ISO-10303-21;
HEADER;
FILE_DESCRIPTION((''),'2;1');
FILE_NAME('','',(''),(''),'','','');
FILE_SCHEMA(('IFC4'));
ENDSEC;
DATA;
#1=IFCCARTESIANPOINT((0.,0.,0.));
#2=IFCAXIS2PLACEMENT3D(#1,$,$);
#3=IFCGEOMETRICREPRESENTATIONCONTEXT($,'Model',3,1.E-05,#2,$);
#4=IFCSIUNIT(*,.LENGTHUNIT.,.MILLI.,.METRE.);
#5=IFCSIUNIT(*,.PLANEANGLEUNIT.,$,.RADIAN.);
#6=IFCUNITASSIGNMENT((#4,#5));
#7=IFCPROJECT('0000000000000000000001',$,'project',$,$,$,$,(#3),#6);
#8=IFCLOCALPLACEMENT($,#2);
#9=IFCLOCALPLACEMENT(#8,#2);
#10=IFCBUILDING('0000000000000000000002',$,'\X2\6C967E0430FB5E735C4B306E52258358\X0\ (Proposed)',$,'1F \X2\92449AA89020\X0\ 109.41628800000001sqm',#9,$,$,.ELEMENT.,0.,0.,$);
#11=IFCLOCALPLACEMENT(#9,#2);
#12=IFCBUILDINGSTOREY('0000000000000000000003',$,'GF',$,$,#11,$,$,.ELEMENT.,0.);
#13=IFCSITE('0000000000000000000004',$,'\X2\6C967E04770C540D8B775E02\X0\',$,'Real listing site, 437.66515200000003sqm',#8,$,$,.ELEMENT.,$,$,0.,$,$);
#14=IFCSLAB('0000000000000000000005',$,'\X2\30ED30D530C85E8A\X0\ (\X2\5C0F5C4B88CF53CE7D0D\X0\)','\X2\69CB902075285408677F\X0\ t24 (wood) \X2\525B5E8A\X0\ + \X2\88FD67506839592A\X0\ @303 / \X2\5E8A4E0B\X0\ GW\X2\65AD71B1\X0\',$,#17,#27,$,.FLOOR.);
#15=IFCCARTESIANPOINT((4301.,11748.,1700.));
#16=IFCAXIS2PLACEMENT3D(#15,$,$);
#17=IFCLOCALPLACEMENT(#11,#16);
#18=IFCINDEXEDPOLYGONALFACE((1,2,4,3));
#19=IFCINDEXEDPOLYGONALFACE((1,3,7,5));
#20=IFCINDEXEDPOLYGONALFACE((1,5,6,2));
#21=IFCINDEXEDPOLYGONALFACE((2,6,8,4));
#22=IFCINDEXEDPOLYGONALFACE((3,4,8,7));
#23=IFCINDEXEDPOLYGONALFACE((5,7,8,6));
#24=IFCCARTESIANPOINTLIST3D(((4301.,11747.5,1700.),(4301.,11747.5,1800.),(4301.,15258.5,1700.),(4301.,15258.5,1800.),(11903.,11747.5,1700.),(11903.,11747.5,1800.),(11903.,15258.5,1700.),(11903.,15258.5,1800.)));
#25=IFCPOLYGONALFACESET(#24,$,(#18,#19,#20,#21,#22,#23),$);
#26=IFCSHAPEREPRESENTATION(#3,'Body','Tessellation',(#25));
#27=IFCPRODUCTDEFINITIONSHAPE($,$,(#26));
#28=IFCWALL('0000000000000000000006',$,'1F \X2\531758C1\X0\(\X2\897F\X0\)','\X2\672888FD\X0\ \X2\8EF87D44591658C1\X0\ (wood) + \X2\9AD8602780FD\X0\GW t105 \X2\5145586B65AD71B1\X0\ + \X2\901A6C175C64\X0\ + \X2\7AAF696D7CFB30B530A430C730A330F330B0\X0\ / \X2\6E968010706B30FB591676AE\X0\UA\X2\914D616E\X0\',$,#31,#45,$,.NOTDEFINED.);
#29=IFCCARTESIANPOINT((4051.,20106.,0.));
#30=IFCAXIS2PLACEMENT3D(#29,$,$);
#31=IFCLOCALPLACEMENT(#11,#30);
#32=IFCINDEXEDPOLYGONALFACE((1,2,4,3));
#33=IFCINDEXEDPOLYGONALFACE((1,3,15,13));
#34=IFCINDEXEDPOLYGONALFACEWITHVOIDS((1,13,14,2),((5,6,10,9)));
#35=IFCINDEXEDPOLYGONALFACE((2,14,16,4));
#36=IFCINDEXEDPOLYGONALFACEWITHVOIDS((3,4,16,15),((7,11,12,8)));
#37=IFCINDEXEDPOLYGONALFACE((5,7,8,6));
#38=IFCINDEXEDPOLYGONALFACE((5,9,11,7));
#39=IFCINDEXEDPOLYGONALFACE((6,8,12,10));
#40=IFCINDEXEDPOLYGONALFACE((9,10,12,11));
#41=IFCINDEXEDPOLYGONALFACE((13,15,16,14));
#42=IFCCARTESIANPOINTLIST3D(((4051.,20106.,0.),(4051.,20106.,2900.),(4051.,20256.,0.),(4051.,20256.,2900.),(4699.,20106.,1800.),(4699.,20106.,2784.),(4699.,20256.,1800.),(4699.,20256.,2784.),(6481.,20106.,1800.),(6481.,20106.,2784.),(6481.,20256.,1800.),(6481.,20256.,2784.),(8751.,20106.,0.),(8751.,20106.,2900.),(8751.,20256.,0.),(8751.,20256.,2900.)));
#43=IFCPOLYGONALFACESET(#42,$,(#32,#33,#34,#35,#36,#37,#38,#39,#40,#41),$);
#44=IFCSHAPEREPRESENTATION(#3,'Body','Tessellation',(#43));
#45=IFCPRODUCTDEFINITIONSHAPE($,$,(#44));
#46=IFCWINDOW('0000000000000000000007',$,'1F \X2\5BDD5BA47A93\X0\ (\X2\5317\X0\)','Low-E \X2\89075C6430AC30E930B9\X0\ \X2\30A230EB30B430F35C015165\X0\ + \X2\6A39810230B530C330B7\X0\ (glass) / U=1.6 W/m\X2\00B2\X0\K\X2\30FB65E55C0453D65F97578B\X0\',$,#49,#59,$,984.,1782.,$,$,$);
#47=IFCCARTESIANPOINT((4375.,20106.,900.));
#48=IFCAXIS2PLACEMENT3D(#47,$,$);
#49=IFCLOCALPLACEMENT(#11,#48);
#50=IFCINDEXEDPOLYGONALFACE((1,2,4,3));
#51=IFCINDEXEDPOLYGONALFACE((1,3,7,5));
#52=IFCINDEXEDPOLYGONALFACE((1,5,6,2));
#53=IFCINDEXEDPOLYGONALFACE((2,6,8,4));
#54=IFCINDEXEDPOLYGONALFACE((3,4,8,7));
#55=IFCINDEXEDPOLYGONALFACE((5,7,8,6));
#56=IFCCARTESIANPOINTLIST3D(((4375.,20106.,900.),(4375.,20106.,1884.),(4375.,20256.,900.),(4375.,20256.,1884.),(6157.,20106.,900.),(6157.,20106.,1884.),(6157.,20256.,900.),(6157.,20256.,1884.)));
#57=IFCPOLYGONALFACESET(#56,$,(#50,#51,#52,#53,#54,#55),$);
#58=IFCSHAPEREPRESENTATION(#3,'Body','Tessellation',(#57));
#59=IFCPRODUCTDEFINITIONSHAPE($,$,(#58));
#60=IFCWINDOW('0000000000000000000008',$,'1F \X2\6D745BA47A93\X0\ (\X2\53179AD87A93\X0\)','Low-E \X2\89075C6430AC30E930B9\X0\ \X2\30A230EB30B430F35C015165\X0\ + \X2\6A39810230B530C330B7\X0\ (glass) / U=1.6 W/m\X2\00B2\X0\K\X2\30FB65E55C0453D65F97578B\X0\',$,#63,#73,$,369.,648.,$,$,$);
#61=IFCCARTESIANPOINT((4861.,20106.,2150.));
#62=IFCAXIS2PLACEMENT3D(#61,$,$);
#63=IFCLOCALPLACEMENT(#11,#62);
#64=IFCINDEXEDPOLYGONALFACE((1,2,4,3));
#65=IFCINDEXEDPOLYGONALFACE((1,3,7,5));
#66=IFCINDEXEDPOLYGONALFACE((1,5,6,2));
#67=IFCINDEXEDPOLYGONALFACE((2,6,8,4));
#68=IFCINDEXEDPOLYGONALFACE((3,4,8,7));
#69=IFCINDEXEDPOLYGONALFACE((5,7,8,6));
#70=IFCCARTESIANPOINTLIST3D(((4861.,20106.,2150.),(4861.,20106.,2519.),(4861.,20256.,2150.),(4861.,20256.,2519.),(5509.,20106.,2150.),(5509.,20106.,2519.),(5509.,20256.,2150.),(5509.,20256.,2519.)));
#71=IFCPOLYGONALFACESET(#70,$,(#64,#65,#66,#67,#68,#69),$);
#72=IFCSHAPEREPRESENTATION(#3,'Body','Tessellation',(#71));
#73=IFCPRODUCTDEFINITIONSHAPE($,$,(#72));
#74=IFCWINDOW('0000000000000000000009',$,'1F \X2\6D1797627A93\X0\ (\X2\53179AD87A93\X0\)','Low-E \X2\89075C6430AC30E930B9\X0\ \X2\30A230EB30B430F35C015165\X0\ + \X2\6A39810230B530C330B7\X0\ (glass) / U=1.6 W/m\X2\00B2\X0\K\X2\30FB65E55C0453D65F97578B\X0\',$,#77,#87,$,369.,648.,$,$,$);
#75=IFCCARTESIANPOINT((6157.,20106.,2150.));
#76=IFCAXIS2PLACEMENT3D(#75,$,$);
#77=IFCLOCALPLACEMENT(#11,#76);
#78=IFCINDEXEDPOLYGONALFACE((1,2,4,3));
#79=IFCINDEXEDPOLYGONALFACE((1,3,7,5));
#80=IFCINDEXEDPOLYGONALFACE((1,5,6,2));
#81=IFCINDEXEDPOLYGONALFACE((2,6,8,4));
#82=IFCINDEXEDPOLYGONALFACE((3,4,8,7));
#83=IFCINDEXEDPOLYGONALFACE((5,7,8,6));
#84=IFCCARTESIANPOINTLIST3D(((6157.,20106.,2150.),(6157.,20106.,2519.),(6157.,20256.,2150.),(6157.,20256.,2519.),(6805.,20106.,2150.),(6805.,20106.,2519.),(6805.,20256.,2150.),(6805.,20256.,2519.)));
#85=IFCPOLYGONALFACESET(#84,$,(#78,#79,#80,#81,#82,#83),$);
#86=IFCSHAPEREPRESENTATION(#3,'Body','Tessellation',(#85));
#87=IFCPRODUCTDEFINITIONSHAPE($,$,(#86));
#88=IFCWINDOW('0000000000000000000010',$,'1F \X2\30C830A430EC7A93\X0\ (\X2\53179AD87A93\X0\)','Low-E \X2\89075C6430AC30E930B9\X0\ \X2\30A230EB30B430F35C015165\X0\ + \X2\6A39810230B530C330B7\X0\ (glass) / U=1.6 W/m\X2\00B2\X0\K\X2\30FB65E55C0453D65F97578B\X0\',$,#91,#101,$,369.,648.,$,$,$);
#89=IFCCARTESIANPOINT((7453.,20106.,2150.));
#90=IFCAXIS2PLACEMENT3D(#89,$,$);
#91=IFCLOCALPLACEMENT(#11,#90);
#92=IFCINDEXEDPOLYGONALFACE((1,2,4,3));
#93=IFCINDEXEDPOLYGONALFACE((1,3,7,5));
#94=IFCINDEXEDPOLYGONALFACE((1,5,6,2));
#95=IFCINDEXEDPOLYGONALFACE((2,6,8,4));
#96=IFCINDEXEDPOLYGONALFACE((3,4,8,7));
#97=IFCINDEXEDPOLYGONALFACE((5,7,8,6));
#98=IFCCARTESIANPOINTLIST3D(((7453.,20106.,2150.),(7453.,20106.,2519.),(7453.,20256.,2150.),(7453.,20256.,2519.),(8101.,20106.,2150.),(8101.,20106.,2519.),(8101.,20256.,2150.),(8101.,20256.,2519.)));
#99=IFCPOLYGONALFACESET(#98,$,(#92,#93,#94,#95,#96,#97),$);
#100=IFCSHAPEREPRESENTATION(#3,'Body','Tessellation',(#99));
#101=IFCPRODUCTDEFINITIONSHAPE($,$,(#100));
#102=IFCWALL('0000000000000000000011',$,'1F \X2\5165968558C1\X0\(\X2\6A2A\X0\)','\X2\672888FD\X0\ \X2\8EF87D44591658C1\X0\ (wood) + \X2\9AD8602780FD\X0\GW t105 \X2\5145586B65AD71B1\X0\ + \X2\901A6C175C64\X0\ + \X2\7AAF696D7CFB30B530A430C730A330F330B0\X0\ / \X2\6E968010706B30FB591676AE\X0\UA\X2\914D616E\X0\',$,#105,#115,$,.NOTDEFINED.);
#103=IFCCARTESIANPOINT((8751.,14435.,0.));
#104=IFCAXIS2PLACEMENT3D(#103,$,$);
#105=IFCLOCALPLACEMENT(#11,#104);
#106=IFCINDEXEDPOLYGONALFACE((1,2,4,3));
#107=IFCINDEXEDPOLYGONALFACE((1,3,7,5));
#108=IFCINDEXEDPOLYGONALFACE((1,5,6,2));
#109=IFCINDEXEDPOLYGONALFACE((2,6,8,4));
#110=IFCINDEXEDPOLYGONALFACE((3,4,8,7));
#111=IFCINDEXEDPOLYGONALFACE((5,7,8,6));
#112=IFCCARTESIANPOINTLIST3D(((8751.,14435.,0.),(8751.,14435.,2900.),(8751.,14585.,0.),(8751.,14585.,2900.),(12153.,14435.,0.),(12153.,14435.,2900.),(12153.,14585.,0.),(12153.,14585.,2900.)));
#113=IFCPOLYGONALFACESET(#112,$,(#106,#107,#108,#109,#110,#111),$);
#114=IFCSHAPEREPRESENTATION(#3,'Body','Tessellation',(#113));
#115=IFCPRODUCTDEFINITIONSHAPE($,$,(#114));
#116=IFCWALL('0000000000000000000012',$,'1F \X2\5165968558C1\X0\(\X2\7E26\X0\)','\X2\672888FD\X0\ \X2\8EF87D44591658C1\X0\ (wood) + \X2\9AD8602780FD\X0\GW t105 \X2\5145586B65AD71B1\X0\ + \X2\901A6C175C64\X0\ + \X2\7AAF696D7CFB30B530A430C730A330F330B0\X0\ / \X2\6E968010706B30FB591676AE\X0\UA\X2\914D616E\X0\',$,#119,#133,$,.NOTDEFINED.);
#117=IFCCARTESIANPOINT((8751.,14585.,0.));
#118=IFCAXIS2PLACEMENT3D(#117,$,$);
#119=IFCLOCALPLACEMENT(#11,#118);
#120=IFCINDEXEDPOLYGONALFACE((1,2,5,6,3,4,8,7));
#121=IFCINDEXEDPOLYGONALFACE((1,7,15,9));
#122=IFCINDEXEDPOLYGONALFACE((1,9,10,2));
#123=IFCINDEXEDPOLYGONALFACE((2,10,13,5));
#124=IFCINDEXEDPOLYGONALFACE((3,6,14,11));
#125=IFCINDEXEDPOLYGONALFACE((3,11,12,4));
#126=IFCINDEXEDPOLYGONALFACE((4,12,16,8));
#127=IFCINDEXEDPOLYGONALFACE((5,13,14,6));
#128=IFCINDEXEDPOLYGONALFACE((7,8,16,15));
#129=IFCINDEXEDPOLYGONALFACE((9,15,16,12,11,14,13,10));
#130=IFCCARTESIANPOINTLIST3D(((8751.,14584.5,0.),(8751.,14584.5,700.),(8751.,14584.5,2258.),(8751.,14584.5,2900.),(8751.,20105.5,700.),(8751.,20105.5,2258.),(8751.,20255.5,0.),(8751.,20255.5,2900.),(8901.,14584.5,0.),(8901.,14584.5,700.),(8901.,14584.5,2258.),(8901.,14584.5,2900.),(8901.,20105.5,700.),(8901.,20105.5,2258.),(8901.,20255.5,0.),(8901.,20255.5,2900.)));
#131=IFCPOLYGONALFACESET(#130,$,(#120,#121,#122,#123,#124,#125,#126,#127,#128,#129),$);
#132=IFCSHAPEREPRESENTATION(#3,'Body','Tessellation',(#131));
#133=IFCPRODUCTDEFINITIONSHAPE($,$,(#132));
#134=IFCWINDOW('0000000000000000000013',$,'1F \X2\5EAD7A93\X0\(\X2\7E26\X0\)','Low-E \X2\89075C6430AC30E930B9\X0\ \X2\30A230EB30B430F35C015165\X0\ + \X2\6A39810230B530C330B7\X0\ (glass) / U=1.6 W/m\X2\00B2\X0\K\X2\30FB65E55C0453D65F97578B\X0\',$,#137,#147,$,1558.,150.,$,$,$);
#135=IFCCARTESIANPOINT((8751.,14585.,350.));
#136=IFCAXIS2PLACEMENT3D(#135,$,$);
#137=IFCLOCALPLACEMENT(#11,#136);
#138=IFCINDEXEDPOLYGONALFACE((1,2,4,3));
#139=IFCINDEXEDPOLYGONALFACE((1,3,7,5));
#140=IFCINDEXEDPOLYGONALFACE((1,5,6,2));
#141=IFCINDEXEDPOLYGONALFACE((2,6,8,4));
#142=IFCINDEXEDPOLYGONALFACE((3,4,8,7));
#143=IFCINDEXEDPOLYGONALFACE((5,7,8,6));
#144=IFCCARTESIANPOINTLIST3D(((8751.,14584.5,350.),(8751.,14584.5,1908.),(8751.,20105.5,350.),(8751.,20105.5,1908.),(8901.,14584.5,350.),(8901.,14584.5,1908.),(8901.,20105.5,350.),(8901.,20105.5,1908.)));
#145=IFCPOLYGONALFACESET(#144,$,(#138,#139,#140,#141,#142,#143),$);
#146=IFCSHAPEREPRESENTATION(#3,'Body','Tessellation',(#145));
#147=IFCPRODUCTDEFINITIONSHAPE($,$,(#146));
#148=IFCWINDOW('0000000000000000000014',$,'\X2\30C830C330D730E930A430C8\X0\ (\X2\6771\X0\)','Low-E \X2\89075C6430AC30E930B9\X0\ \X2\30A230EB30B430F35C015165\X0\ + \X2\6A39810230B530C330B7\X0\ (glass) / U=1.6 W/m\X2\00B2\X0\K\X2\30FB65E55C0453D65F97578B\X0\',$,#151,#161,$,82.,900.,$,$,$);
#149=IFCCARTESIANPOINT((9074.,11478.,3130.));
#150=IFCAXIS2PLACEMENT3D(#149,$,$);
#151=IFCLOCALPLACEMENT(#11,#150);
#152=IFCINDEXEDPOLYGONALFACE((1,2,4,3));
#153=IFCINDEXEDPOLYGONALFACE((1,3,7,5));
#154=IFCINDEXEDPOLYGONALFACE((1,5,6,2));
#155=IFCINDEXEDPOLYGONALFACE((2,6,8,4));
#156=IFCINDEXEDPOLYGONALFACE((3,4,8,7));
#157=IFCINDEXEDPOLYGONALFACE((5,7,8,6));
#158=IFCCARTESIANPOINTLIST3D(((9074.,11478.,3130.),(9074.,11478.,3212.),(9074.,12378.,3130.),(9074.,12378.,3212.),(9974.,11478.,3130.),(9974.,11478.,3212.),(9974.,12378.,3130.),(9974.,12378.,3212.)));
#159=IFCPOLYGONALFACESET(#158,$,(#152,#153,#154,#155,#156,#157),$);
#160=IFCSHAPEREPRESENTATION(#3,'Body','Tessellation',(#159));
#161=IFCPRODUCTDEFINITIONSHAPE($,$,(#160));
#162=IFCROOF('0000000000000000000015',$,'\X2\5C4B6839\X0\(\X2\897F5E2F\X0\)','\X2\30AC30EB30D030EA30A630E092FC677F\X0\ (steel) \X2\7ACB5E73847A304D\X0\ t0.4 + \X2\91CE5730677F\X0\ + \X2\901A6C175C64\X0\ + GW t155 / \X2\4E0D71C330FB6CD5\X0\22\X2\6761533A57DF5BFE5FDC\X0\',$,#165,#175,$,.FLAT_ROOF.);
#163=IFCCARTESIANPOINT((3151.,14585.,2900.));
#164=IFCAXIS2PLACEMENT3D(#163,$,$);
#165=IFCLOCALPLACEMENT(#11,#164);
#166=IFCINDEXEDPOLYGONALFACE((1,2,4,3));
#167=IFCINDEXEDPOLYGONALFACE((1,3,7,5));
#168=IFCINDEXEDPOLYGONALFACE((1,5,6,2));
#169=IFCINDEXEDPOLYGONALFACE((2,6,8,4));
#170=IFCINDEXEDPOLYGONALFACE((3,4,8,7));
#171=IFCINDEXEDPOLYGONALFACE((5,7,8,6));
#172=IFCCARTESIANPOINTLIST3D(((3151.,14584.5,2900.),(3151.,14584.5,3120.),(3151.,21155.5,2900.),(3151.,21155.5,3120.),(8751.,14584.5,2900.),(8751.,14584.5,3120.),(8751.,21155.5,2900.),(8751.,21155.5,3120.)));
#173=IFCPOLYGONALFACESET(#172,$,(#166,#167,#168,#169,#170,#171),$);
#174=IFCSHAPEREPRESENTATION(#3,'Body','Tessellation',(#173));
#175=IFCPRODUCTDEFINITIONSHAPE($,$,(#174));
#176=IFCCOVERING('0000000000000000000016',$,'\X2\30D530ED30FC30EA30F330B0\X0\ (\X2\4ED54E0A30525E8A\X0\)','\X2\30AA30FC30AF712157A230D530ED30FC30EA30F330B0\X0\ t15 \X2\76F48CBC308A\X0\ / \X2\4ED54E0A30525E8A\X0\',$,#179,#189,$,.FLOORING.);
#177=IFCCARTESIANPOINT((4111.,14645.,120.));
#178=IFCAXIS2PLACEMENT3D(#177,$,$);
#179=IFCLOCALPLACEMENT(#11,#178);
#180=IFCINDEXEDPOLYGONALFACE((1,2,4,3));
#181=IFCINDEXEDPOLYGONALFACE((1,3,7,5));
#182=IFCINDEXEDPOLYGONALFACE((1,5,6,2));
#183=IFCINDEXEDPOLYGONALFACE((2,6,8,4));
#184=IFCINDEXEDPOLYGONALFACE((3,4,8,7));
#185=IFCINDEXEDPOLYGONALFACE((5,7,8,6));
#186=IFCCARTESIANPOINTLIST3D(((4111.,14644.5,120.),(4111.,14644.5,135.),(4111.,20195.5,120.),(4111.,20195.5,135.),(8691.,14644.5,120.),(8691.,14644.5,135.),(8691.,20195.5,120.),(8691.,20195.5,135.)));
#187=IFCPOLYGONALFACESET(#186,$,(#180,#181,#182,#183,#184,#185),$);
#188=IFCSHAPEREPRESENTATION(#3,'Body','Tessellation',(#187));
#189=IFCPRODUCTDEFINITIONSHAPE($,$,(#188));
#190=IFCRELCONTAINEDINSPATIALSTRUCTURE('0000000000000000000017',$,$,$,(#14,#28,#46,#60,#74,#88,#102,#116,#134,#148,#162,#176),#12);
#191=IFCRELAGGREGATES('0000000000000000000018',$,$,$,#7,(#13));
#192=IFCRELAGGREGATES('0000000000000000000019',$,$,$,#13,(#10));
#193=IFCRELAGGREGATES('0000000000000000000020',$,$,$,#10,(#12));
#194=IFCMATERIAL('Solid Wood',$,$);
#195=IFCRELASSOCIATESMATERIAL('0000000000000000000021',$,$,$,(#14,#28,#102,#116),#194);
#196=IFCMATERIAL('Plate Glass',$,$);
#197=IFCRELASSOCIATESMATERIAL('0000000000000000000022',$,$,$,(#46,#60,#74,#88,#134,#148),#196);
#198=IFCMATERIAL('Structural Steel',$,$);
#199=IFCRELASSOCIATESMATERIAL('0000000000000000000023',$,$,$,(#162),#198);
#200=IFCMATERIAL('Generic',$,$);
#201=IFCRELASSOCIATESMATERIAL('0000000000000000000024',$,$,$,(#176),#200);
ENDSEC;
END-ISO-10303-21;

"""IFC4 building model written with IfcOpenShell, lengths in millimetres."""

from ifc_helpers import new_model, si_unit, frame, frame_2d, origin, place, context, project, spatial, rectangle, extrude, material, element, fill, save


model = new_model("IFC4")

# Units and contexts
model_context = context("Model", 3, precision=1e-05, world=origin())
ifc_project = project(units=[si_unit("LENGTHUNIT", "METRE", prefix="MILLI"), si_unit("PLANEANGLEUNIT", "RADIAN")], contexts=[model_context])

# Site, building, storey
site_placement = place(None, origin())
site = spatial("IfcSite", under=ifc_project, at=site_placement, Name="沖縄県名護市", ObjectType="Real listing site, 437.66515200000003sqm", CompositionType="ELEMENT", RefElevation=0.0)
building_placement = place(site_placement, origin())
building = spatial("IfcBuilding", under=site, at=building_placement, Name="沖縄・平屋の別荘 (Proposed)", ObjectType="1F 鉄骨造 109.41628800000001sqm", CompositionType="ELEMENT", ElevationOfRefHeight=0.0, ElevationOfTerrain=0.0)
storey_placement = place(building_placement, origin())
storey = spatial("IfcBuildingStorey", under=building, at=storey_placement, Name="GF", CompositionType="ELEMENT", Elevation=0.0)

# Slab
ifc_material_1 = material(Name="Solid Wood")
slab_1_placement = place(storey_placement, frame((4301.0, 11748.0, 1700.0)))
element("IfcSlab", 1, at=slab_1_placement, inside=storey, material=ifc_material_1, Name="ロフト床 (小屋裏収納)", Description="構造用合板 t24 (wood) 剛床 + 製材根太 @303 / 床下 GW断熱", PredefinedType="FLOOR", context=model_context, shape_type="SweptSolid", body=[
    extrude(rectangle(XDim=7602.0, YDim=3511.0, at=frame_2d((3801.0, 1755.0))), frame((4301.0, 11748.0, 1700.0)), (0.0, 0.0, 1.0), 100.0),
])

# Wall, openings, windows
wall_1_placement = place(storey_placement, frame((4051.0, 20106.0, 0.0)))
wall_1 = element("IfcWall", 2, at=wall_1_placement, inside=storey, material=ifc_material_1, Name="1F 北壁(西)", Description="木製 軸組外壁 (wood) + 高性能GW t105 充填断熱 + 通気層 + 窯業系サイディング / 準耐火・外皮UA配慮", PredefinedType="NOTDEFINED", context=model_context, shape_type="SweptSolid", body=[
    extrude(rectangle(XDim=4700.0, YDim=150.0, at=frame_2d((2350.0, 75.0))), frame((4051.0, 20106.0, 0.0)), (0.0, 0.0, 1.0), 2900.0),
])
opening_1_placement = place(storey_placement, frame((4375.0, 20106.0, 900.0)))
opening_1 = element("IfcOpeningElement", 3, at=opening_1_placement, cuts=wall_1, PredefinedType="NOTDEFINED", context=model_context, shape_type="SweptSolid", body=[
    extrude(rectangle(XDim=1782.0, YDim=150.0, at=frame_2d((891.0, 75.0))), frame((4375.0, 20106.0, 900.0)), (0.0, 0.0, 1.0), 984.0),
])
opening_2_placement = place(storey_placement, frame((4861.0, 20106.0, 2150.0)))
opening_2 = element("IfcOpeningElement", 4, at=opening_2_placement, cuts=wall_1, PredefinedType="NOTDEFINED", context=model_context, shape_type="SweptSolid", body=[
    extrude(rectangle(XDim=648.0, YDim=150.0, at=frame_2d((324.0, 75.0))), frame((4861.0, 20106.0, 2150.0)), (0.0, 0.0, 1.0), 369.0),
])
opening_3_placement = place(storey_placement, frame((6157.0, 20106.0, 2150.0)))
opening_3 = element("IfcOpeningElement", 5, at=opening_3_placement, cuts=wall_1, PredefinedType="NOTDEFINED", context=model_context, shape_type="SweptSolid", body=[
    extrude(rectangle(XDim=648.0, YDim=150.0, at=frame_2d((324.0, 75.0))), frame((6157.0, 20106.0, 2150.0)), (0.0, 0.0, 1.0), 369.0),
])
opening_4_placement = place(storey_placement, frame((7453.0, 20106.0, 2150.0)))
opening_4 = element("IfcOpeningElement", 6, at=opening_4_placement, cuts=wall_1, PredefinedType="NOTDEFINED", context=model_context, shape_type="SweptSolid", body=[
    extrude(rectangle(XDim=648.0, YDim=150.0, at=frame_2d((324.0, 75.0))), frame((7453.0, 20106.0, 2150.0)), (0.0, 0.0, 1.0), 369.0),
])
ifc_material_2 = material(Name="Plate Glass")
window_1_placement = place(storey_placement, frame((4375.0, 20106.0, 900.0)))
window_1 = element("IfcWindow", 7, at=window_1_placement, inside=storey, material=ifc_material_2, Name="1F 寝室窓 (北)", Description="Low-E 複層ガラス アルゴン封入 + 樹脂サッシ (glass) / U=1.6 W/m²K・日射取得型", OverallHeight=984.0, OverallWidth=1782.0, context=model_context, shape_type="SweptSolid", body=[
    extrude(rectangle(XDim=1782.0, YDim=150.0, at=frame_2d((891.0, 75.0))), frame((4375.0, 20106.0, 900.0)), (0.0, 0.0, 1.0), 984.0),
])
fill(opening_1, window_1)
window_2_placement = place(storey_placement, frame((4861.0, 20106.0, 2150.0)))
window_2 = element("IfcWindow", 8, at=window_2_placement, inside=storey, material=ifc_material_2, Name="1F 浴室窓 (北高窓)", Description="Low-E 複層ガラス アルゴン封入 + 樹脂サッシ (glass) / U=1.6 W/m²K・日射取得型", OverallHeight=369.0, OverallWidth=648.0, context=model_context, shape_type="SweptSolid", body=[
    extrude(rectangle(XDim=648.0, YDim=150.0, at=frame_2d((324.0, 75.0))), frame((4861.0, 20106.0, 2150.0)), (0.0, 0.0, 1.0), 369.0),
])
fill(opening_2, window_2)
window_3_placement = place(storey_placement, frame((6157.0, 20106.0, 2150.0)))
window_3 = element("IfcWindow", 9, at=window_3_placement, inside=storey, material=ifc_material_2, Name="1F 洗面窓 (北高窓)", Description="Low-E 複層ガラス アルゴン封入 + 樹脂サッシ (glass) / U=1.6 W/m²K・日射取得型", OverallHeight=369.0, OverallWidth=648.0, context=model_context, shape_type="SweptSolid", body=[
    extrude(rectangle(XDim=648.0, YDim=150.0, at=frame_2d((324.0, 75.0))), frame((6157.0, 20106.0, 2150.0)), (0.0, 0.0, 1.0), 369.0),
])
fill(opening_3, window_3)
window_4_placement = place(storey_placement, frame((7453.0, 20106.0, 2150.0)))
window_4 = element("IfcWindow", 10, at=window_4_placement, inside=storey, material=ifc_material_2, Name="1F トイレ窓 (北高窓)", Description="Low-E 複層ガラス アルゴン封入 + 樹脂サッシ (glass) / U=1.6 W/m²K・日射取得型", OverallHeight=369.0, OverallWidth=648.0, context=model_context, shape_type="SweptSolid", body=[
    extrude(rectangle(XDim=648.0, YDim=150.0, at=frame_2d((324.0, 75.0))), frame((7453.0, 20106.0, 2150.0)), (0.0, 0.0, 1.0), 369.0),
])
fill(opening_4, window_4)

# Wall
wall_2_placement = place(storey_placement, frame((8751.0, 14435.0, 0.0)))
element("IfcWall", 11, at=wall_2_placement, inside=storey, material=ifc_material_1, Name="1F 入隅壁(横)", Description="木製 軸組外壁 (wood) + 高性能GW t105 充填断熱 + 通気層 + 窯業系サイディング / 準耐火・外皮UA配慮", PredefinedType="NOTDEFINED", context=model_context, shape_type="SweptSolid", body=[
    extrude(rectangle(XDim=3402.0, YDim=150.0, at=frame_2d((1701.0, 75.0))), frame((8751.0, 14435.0, 0.0)), (0.0, 0.0, 1.0), 2900.0),
])

# Wall, opening, window
wall_3_placement = place(storey_placement, frame((8751.0, 14585.0, 0.0)))
wall_3 = element("IfcWall", 12, at=wall_3_placement, inside=storey, material=ifc_material_1, Name="1F 入隅壁(縦)", Description="木製 軸組外壁 (wood) + 高性能GW t105 充填断熱 + 通気層 + 窯業系サイディング / 準耐火・外皮UA配慮", PredefinedType="NOTDEFINED", context=model_context, shape_type="SweptSolid", body=[
    extrude(rectangle(XDim=150.0, YDim=5671.0, at=frame_2d((75.0, 2835.0))), frame((8751.0, 14585.0, 0.0)), (0.0, 0.0, 1.0), 2900.0),
])
opening_5_placement = place(storey_placement, frame((8751.0, 14585.0, 350.0)))
opening_5 = element("IfcOpeningElement", 13, at=opening_5_placement, cuts=wall_3, PredefinedType="NOTDEFINED", context=model_context, shape_type="SweptSolid", body=[
    extrude(rectangle(XDim=150.0, YDim=5521.0, at=frame_2d((75.0, 2760.0))), frame((8751.0, 14585.0, 350.0)), (0.0, 0.0, 1.0), 1558.0),
])
window_5_placement = place(storey_placement, frame((8751.0, 14585.0, 350.0)))
window_5 = element("IfcWindow", 14, at=window_5_placement, inside=storey, material=ifc_material_2, Name="1F 庭窓(縦)", Description="Low-E 複層ガラス アルゴン封入 + 樹脂サッシ (glass) / U=1.6 W/m²K・日射取得型", OverallHeight=1558.0, OverallWidth=150.0, context=model_context, shape_type="SweptSolid", body=[
    extrude(rectangle(XDim=150.0, YDim=5521.0, at=frame_2d((75.0, 2760.0))), frame((8751.0, 14585.0, 350.0)), (0.0, 0.0, 1.0), 1558.0),
])
fill(opening_5, window_5)

# Window
window_6_placement = place(storey_placement, frame((9074.0, 11478.0, 3130.0)))
element("IfcWindow", 15, at=window_6_placement, inside=storey, material=ifc_material_2, Name="トップライト (東)", Description="Low-E 複層ガラス アルゴン封入 + 樹脂サッシ (glass) / U=1.6 W/m²K・日射取得型", OverallHeight=82.0, OverallWidth=900.0, context=model_context, shape_type="SweptSolid", body=[
    extrude(rectangle(XDim=900.0, YDim=900.0, at=frame_2d((450.0, 450.0))), frame((9074.0, 11478.0, 3130.0)), (0.0, 0.0, 1.0), 82.0),
])

# Roof
ifc_material_3 = material(Name="Structural Steel")
roof_placement = place(storey_placement, frame((3151.0, 14585.0, 2900.0)))
element("IfcRoof", 16, at=roof_placement, inside=storey, material=ifc_material_3, Name="屋根(西帯)", Description="ガルバリウム鋼板 (steel) 立平葺き t0.4 + 野地板 + 通気層 + GW t155 / 不燃・法22条区域対応", PredefinedType="FLAT_ROOF", context=model_context, shape_type="SweptSolid", body=[
    extrude(rectangle(XDim=5600.0, YDim=6571.0, at=frame_2d((2800.0, 3285.0))), frame((3151.0, 14585.0, 2900.0)), (0.0, 0.0, 1.0), 220.0),
])

# Covering
ifc_material_4 = material(Name="Generic")
covering_placement = place(storey_placement, frame((4111.0, 14645.0, 120.0)))
element("IfcCovering", 17, at=covering_placement, inside=storey, material=ifc_material_4, Name="フローリング (仕上げ床)", Description="オーク無垢フローリング t15 直貼り / 仕上げ床", PredefinedType="FLOORING", context=model_context, shape_type="SweptSolid", body=[
    extrude(rectangle(XDim=4580.0, YDim=5551.0, at=frame_2d((2290.0, 2775.0))), frame((4111.0, 14645.0, 120.0)), (0.0, 0.0, 1.0), 15.0),
])

save(model, "model.ifc")
